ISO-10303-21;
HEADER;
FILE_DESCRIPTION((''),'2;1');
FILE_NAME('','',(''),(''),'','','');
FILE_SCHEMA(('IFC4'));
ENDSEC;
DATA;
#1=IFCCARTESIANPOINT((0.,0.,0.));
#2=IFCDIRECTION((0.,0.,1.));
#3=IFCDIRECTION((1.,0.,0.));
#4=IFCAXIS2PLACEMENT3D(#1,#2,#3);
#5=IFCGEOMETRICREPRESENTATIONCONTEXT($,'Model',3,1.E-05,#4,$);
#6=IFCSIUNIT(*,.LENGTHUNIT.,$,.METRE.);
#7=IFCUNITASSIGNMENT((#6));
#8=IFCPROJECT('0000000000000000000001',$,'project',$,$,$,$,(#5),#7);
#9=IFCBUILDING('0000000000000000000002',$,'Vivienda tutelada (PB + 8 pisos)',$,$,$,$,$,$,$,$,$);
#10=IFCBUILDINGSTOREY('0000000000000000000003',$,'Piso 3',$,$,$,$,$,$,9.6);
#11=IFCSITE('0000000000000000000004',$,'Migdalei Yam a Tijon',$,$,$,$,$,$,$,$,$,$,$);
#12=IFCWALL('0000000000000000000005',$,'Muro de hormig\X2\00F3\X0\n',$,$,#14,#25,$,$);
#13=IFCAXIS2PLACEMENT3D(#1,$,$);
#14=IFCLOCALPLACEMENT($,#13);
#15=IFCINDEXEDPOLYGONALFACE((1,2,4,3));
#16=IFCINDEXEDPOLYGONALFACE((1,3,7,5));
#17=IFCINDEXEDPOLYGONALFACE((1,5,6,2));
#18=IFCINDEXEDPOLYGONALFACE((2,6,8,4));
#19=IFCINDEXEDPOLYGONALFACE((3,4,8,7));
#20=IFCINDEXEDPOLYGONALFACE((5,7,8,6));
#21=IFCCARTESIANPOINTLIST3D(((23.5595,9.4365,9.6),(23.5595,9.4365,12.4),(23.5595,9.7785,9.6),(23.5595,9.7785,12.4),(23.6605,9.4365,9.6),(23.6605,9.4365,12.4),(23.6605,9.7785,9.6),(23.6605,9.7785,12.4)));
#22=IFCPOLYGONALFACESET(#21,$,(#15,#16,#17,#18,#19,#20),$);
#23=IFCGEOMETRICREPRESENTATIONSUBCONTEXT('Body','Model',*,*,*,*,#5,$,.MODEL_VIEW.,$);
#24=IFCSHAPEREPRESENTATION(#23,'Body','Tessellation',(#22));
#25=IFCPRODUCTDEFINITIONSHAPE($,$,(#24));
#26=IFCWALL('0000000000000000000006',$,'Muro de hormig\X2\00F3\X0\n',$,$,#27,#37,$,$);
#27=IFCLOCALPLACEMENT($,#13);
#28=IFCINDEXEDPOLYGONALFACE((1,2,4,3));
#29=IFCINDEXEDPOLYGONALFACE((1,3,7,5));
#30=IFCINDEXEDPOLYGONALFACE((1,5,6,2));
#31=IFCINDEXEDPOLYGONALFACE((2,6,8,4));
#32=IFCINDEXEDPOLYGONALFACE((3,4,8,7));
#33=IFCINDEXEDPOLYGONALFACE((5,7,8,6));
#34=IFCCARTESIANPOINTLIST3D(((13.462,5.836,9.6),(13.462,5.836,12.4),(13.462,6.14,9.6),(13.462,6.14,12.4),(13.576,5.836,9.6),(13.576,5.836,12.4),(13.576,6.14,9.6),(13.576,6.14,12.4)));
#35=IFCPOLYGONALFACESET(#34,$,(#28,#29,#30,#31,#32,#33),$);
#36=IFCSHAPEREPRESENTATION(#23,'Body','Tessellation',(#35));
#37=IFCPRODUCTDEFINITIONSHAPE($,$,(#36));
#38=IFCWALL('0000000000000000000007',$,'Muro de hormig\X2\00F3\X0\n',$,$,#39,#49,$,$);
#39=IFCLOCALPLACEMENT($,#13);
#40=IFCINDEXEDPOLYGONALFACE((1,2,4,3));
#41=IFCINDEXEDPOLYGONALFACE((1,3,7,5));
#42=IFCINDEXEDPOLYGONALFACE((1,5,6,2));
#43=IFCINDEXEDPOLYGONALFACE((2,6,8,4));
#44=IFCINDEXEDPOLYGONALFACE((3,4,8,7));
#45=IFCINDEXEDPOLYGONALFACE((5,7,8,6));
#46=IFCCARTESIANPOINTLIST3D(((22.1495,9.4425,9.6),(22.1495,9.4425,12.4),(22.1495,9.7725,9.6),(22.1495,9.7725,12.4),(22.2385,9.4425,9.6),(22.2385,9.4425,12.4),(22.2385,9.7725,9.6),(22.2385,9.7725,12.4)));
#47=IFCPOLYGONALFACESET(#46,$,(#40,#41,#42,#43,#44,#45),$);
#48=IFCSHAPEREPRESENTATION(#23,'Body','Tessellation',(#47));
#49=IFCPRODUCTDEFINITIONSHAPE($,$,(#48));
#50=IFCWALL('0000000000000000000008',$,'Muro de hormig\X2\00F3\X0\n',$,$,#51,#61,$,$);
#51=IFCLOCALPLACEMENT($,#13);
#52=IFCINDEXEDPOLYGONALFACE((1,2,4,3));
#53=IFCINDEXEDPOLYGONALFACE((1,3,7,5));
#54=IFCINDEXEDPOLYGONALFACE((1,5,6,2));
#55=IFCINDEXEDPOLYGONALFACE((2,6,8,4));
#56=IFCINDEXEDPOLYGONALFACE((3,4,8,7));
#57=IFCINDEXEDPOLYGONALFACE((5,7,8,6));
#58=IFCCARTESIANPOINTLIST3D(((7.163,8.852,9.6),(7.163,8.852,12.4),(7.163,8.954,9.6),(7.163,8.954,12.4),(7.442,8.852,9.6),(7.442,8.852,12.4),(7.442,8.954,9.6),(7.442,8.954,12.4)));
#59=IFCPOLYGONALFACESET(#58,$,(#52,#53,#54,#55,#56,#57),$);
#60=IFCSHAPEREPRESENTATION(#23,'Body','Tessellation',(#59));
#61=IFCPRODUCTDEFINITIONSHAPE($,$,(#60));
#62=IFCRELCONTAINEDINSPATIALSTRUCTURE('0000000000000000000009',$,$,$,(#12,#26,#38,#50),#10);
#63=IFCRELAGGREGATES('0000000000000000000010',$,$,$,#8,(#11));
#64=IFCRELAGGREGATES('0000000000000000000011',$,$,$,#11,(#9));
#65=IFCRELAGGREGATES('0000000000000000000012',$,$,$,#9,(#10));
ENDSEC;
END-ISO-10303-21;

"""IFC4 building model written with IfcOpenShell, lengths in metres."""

from ifc_helpers import new_model, si_unit, frame, origin_with_axes, context, subcontext, project, spatial, line, indexed_curve, outline, extrude, element, save


model = new_model("IFC4")

# Units and contexts
model_context = context("Model", 3, precision=1e-05, world=origin_with_axes())
body_context = subcontext(model_context, "Body", "Model", "MODEL_VIEW")
ifc_project = project(units=[si_unit("LENGTHUNIT", "METRE")], contexts=[model_context])

# Site, building, storey
site = spatial("IfcSite", under=ifc_project, Name="Migdalei Yam a Tijon")
building = spatial("IfcBuilding", under=site, Name="Vivienda tutelada (PB + 8 pisos)")
storey = spatial("IfcBuildingStorey", under=building, Name="Piso 3", Elevation=9.6)

# Walls
element("IfcWall", 1, inside=storey, Name="Muro de hormigón", context=body_context, shape_type="SweptSolid", body=[
    extrude(outline(indexed_curve([(0.0, 0.0), (0.101, 0.0), (0.101, 0.342), (0.0, 0.342)], segments=[line(1, 2, 3, 4, 1)])), frame((23.5595, 9.4365, 9.6), z_axis=(0.0, 0.0, 1.0), x_axis=(1.0, 0.0, 0.0)), (0.0, 0.0, 1.0), 2.8),
])
element("IfcWall", 2, inside=storey, Name="Muro de hormigón", context=body_context, shape_type="SweptSolid", body=[
    extrude(outline(indexed_curve([(0.0, 0.0), (0.114, 0.0), (0.114, 0.304), (0.0, 0.304)], segments=[line(1, 2, 3, 4, 1)])), frame((13.462, 5.836, 9.6), z_axis=(0.0, 0.0, 1.0), x_axis=(1.0, 0.0, 0.0)), (0.0, 0.0, 1.0), 2.8),
])
element("IfcWall", 3, inside=storey, Name="Muro de hormigón", context=body_context, shape_type="SweptSolid", body=[
    extrude(outline(indexed_curve([(0.0, 0.0), (0.089, 0.0), (0.089, 0.33), (0.0, 0.33)], segments=[line(1, 2, 3, 4, 1)])), frame((22.1495, 9.4425, 9.6), z_axis=(0.0, 0.0, 1.0), x_axis=(1.0, 0.0, 0.0)), (0.0, 0.0, 1.0), 2.8),
])
element("IfcWall", 4, inside=storey, Name="Muro de hormigón", context=body_context, shape_type="SweptSolid", body=[
    extrude(outline(indexed_curve([(0.0, 0.0), (0.279, 0.0), (0.279, 0.102), (0.0, 0.102)], segments=[line(1, 2, 3, 4, 1)])), frame((7.163, 8.852, 9.6), z_axis=(0.0, 0.0, 1.0), x_axis=(1.0, 0.0, 0.0)), (0.0, 0.0, 1.0), 2.8),
])

save(model, "model.ifc")
